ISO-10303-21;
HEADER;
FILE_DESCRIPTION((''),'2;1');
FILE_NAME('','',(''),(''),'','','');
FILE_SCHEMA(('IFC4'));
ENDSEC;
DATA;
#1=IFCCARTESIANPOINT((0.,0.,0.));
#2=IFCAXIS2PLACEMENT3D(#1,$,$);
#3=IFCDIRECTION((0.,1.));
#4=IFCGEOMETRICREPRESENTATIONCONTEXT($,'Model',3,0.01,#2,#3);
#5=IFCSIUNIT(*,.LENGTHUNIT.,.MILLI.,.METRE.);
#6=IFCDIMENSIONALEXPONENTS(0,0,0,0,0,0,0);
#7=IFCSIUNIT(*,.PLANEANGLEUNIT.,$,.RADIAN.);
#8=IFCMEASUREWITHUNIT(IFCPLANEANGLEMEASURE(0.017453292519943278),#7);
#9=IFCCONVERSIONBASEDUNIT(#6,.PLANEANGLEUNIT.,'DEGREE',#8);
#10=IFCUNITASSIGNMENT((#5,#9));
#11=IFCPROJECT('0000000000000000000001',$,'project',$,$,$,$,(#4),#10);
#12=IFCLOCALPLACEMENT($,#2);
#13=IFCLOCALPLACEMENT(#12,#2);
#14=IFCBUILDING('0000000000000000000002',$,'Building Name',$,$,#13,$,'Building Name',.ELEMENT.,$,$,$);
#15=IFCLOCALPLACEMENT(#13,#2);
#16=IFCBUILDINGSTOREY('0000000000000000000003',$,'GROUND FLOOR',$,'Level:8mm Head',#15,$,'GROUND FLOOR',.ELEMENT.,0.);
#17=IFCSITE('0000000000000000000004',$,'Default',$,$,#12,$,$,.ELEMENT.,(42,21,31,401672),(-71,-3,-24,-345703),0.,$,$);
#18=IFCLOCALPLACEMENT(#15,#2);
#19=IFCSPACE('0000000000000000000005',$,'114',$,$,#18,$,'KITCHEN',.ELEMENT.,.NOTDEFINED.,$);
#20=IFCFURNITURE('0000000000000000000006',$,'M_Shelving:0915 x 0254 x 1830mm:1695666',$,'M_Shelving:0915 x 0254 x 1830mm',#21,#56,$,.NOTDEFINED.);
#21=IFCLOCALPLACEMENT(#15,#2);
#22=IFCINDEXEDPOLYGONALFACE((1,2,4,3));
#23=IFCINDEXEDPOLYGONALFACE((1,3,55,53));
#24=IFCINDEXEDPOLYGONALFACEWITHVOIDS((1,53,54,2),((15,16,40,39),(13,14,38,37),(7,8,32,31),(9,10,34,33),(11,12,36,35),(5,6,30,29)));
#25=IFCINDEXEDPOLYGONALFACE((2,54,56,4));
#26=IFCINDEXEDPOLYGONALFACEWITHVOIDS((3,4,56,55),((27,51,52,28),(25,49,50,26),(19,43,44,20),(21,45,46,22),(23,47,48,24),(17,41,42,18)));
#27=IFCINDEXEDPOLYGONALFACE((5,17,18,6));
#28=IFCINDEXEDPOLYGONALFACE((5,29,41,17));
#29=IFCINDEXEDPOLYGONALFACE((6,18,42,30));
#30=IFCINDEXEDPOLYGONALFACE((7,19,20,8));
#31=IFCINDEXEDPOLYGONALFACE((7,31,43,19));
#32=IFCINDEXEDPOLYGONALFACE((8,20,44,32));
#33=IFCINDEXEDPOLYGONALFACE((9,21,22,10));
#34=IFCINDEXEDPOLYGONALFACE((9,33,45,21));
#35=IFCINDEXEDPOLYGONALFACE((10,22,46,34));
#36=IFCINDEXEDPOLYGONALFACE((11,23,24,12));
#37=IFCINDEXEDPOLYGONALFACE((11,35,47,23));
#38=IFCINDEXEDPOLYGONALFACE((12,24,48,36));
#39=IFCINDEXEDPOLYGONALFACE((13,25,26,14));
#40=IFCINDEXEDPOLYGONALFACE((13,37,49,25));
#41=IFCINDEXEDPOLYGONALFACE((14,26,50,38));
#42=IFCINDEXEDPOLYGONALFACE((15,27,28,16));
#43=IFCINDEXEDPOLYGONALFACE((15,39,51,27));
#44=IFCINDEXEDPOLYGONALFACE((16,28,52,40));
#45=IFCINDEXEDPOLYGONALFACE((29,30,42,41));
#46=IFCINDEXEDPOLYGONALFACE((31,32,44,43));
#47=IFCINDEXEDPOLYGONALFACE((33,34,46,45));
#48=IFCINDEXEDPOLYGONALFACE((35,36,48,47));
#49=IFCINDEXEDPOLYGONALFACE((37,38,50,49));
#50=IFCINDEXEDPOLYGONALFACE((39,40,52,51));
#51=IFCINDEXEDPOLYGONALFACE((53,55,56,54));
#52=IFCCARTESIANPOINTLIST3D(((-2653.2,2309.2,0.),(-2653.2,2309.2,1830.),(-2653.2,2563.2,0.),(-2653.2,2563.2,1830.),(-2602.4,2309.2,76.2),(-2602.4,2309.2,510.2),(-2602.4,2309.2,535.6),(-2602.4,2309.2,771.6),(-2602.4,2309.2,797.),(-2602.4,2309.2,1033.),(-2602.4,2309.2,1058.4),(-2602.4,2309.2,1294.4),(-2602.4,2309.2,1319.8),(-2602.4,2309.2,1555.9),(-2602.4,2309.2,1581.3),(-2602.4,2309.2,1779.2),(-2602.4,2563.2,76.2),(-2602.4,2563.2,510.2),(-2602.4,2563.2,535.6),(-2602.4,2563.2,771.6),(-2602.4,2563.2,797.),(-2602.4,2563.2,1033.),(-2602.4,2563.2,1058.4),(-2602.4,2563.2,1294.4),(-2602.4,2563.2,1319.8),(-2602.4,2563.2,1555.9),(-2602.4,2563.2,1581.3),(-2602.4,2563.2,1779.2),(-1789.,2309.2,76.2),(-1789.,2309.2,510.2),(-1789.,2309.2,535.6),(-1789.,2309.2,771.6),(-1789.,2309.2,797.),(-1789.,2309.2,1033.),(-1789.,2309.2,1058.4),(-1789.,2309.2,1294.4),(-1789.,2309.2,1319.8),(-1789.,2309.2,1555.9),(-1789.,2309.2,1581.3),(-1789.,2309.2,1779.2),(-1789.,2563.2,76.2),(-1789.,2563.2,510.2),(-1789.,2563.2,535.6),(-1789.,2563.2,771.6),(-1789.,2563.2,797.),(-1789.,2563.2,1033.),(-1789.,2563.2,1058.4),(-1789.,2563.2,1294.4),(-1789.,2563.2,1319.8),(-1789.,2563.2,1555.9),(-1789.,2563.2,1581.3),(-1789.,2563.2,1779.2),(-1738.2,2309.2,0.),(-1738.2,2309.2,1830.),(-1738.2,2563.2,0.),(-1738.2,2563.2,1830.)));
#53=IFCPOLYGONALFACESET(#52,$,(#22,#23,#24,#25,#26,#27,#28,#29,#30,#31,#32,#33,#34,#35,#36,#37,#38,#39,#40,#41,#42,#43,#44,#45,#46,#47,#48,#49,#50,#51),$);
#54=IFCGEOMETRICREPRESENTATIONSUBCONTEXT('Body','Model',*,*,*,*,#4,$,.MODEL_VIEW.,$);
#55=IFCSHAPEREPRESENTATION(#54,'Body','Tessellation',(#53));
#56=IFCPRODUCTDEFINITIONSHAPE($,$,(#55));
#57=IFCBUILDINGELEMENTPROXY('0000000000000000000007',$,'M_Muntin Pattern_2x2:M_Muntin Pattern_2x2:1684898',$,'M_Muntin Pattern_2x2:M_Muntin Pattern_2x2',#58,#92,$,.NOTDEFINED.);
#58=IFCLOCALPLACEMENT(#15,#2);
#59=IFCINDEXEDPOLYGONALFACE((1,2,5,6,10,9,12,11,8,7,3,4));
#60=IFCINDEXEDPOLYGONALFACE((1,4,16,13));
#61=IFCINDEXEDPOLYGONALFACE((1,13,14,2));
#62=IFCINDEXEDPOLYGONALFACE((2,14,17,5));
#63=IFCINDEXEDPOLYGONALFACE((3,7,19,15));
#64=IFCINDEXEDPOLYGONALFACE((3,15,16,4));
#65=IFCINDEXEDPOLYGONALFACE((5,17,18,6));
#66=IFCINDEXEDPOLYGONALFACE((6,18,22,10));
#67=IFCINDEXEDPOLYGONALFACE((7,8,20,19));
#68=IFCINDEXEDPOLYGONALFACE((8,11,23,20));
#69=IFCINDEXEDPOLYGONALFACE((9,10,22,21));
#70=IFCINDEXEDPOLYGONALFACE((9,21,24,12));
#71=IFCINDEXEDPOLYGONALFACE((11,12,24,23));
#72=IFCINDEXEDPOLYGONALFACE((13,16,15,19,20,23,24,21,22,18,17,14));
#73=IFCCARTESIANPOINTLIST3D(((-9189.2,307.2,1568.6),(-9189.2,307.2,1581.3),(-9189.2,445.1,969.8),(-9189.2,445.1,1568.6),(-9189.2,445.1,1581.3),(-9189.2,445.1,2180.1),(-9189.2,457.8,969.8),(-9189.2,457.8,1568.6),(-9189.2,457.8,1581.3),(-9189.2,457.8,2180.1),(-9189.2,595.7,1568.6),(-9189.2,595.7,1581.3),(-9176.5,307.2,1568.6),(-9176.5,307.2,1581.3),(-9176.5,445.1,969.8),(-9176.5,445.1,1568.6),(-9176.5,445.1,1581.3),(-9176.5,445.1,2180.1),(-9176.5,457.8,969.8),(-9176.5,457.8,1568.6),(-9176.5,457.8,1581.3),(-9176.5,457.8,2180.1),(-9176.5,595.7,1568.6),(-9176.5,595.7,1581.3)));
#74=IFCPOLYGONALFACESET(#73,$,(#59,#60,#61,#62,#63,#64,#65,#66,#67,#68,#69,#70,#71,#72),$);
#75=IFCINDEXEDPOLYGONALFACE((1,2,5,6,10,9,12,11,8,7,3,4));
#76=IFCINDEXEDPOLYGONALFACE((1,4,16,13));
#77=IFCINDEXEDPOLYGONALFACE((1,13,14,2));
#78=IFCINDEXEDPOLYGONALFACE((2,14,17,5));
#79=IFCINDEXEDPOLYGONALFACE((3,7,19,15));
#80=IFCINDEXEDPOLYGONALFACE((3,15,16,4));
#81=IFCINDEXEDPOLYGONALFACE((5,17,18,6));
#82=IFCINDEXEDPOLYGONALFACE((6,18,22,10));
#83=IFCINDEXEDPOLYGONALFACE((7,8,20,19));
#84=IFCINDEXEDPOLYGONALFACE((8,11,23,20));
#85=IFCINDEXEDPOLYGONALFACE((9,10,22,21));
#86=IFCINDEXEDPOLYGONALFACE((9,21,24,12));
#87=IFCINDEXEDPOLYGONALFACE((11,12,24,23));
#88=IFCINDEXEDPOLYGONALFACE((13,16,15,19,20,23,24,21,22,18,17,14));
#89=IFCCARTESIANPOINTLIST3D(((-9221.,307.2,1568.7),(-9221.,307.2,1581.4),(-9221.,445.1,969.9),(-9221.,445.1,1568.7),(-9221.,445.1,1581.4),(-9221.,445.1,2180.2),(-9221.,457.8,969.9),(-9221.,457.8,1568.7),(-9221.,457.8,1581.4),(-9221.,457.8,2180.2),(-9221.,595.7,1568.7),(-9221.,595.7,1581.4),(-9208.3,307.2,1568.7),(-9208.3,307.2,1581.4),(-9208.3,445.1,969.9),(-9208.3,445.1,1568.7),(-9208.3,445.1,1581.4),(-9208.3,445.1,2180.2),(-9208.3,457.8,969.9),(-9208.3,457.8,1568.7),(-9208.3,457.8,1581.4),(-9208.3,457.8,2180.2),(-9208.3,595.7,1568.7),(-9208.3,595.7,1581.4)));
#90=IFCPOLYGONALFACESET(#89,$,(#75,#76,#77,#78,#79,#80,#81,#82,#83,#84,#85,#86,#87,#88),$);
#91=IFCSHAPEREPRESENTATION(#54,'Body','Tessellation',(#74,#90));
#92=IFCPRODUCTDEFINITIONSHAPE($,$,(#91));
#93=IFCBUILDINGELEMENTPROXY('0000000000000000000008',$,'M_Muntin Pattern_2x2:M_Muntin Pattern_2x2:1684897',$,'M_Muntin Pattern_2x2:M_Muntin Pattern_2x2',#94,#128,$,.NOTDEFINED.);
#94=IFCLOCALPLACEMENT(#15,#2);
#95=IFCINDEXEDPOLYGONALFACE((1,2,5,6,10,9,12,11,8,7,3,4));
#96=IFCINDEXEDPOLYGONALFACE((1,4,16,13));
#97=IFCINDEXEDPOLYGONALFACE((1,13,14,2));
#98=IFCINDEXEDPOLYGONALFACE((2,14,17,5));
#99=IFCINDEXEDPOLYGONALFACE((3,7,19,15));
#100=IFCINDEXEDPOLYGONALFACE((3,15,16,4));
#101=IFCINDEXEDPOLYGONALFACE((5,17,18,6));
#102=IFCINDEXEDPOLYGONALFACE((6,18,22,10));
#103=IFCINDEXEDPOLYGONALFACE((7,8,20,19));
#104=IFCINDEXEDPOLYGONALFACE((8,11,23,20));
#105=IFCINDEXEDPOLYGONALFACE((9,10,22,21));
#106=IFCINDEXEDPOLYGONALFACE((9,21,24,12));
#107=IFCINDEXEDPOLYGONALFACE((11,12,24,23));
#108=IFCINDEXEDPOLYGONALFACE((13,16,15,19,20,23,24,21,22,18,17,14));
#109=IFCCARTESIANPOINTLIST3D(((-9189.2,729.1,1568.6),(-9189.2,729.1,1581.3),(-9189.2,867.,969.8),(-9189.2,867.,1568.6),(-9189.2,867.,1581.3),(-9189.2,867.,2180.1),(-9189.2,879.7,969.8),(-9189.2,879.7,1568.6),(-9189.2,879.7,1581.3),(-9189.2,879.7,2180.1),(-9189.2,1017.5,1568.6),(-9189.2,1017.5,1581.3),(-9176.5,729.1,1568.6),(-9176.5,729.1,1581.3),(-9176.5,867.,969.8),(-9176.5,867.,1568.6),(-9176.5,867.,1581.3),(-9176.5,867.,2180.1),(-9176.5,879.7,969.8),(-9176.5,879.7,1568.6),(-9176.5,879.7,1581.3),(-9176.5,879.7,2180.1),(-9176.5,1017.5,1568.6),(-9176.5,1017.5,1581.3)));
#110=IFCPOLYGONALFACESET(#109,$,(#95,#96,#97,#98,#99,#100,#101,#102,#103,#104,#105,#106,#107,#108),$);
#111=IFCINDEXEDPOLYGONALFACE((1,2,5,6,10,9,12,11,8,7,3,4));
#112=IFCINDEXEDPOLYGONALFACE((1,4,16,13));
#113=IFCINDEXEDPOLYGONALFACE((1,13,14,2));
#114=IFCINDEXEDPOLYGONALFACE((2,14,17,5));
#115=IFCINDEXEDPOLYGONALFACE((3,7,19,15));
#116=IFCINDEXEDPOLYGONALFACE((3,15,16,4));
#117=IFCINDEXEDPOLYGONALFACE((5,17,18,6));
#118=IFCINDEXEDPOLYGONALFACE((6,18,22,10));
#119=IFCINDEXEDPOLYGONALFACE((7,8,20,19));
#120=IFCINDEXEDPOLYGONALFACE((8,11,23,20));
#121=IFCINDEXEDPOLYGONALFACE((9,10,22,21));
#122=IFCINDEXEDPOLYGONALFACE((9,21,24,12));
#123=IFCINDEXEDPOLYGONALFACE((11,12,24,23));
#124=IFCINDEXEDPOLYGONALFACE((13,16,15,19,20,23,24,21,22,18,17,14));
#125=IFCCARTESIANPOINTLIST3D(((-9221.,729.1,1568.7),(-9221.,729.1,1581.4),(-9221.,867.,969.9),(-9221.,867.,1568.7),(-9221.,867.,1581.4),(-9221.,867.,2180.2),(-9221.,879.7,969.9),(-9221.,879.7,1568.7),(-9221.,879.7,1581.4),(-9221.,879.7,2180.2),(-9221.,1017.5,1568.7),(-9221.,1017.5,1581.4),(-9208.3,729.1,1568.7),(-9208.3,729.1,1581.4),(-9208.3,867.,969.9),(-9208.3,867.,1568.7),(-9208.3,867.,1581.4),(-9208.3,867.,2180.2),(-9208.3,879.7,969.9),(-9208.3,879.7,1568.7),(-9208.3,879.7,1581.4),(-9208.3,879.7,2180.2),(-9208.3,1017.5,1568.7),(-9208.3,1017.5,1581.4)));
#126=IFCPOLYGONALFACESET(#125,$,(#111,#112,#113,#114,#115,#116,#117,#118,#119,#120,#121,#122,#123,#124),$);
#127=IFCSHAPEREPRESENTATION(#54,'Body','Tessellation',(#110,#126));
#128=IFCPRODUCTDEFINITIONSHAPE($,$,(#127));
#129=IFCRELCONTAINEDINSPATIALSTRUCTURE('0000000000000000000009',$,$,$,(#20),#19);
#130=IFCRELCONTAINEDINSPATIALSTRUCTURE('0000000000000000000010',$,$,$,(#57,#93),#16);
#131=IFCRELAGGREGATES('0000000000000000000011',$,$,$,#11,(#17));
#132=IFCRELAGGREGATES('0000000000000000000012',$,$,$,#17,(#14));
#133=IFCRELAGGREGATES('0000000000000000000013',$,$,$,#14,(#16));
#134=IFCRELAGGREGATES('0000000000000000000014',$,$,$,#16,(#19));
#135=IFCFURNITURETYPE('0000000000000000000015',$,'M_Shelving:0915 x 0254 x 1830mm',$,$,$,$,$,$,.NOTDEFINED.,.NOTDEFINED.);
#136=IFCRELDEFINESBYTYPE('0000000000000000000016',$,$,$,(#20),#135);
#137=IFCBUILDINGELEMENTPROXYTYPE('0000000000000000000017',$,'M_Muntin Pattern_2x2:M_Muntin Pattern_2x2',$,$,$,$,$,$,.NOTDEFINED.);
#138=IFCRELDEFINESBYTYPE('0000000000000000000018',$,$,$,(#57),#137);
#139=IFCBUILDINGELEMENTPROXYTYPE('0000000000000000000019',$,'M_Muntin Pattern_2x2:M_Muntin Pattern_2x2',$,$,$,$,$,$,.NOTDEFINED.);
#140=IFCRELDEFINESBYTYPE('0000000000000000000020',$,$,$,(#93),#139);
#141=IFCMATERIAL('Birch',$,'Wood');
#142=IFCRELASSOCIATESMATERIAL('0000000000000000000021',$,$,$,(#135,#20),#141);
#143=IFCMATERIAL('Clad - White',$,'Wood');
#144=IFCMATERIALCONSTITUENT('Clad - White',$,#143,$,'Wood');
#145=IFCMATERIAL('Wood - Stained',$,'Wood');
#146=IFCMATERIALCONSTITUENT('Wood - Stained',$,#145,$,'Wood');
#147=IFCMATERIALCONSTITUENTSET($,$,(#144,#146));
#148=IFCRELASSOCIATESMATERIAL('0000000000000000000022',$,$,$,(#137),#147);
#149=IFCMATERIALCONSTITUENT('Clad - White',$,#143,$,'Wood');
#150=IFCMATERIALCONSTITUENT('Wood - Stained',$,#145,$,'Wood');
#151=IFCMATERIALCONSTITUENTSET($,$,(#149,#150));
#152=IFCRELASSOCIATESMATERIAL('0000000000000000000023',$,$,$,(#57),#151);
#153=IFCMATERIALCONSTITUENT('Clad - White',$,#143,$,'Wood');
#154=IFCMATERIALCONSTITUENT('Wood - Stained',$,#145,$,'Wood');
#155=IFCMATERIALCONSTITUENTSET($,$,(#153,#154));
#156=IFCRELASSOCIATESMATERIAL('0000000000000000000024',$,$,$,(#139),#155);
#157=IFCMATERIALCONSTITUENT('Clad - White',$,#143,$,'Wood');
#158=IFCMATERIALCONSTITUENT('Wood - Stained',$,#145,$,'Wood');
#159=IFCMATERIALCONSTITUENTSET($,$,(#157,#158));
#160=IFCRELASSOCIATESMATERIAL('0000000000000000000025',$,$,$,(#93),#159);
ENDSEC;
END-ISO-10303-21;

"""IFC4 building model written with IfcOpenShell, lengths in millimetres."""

from ifc_helpers import new_model, entity, si_unit, converted_unit, direction, frame, origin, place, context, subcontext, project, spatial, indexed_curve, outline, extrude, source, transform, mapped, material, constituent, constituent_set, type_object, type_shapes, element, save


model = new_model("IFC4")

# Units and contexts
model_context = context("Model", 3, precision=0.01, world=origin(), true_north=direction((0.0, 1.0)))
body_context = subcontext(model_context, "Body", "Model", "MODEL_VIEW")
ifc_project = project(units=[si_unit("LENGTHUNIT", "METRE", prefix="MILLI"), converted_unit("PLANEANGLEUNIT", "DEGREE", entity("IfcPlaneAngleMeasure", 0.017453292519943278), si_unit("PLANEANGLEUNIT", "RADIAN"), dimensions=[0, 0, 0, 0, 0, 0, 0])], contexts=[model_context])

# Site, building, storey
site_placement = place(None, origin())
site = spatial("IfcSite", under=ifc_project, at=site_placement, Name="Default", CompositionType="ELEMENT", RefLatitude=(42, 21, 31, 401672), RefLongitude=(-71, -3, -24, -345703), RefElevation=0.0)
building_placement = place(site_placement, origin())
building = spatial("IfcBuilding", under=site, at=building_placement, Name="Building Name", LongName="Building Name", CompositionType="ELEMENT")
storey_placement = place(building_placement, origin())
storey = spatial("IfcBuildingStorey", under=building, at=storey_placement, Name="GROUND FLOOR", ObjectType="Level:8mm Head", LongName="GROUND FLOOR", CompositionType="ELEMENT", Elevation=0.0)

# Shared definitions
ifc_material_1 = material(Name="Wood - Stained", Category="Wood")

# Shared definitions
space_1_placement = place(storey_placement, origin())
space_1 = spatial("IfcSpace", under=storey, at=space_1_placement, Name="114", LongName="KITCHEN", CompositionType="ELEMENT", PredefinedType="NOTDEFINED")

# Furniture
ifc_material_2 = material(Name="Birch", Category="Wood")
furniture_type_1 = type_object("IfcFurnitureType", Name="M_Shelving:0915 x 0254 x 1830mm", AssemblyPlace="NOTDEFINED", PredefinedType="NOTDEFINED", material=ifc_material_2)
shared_shape_1 = source(origin(), body_context, "Body", "SweptSolid", [
    extrude(outline(indexed_curve([(-457.5, -915.0), (457.5, -915.0), (457.5, 915.0), (-457.5, 915.0), (-457.5, -915.0)], self_intersect=False), holes=[indexed_curve([(-406.7, 864.2), (406.7, 864.2), (406.7, 666.3), (-406.7, 666.3), (-406.7, 864.2)], self_intersect=False), indexed_curve([(-406.7, -838.8), (-406.7, -404.8), (406.7, -404.8), (406.7, -838.8), (-406.7, -838.8)], self_intersect=False), indexed_curve([(406.7, 143.4), (-406.7, 143.4), (-406.7, 379.4), (406.7, 379.4), (406.7, 143.4)], self_intersect=False), indexed_curve([(-406.7, 640.9), (406.7, 640.9), (406.7, 404.8), (-406.7, 404.8), (-406.7, 640.9)], self_intersect=False), indexed_curve([(-406.7, 118.0), (406.7, 118.0), (406.7, -118.0), (-406.7, -118.0), (-406.7, 118.0)], self_intersect=False), indexed_curve([(-406.7, -143.4), (406.7, -143.4), (406.7, -379.4), (-406.7, -379.4), (-406.7, -143.4)], self_intersect=False)]), frame((0.0, -431.8, 915.0), z_axis=(0.0, 1.0, 0.0), x_axis=(-1.0, 0.0, 0.0)), (0.0, 0.0, 1.0), 254.0),
])
type_shapes(furniture_type_1, [shared_shape_1])
for number, where, name in (
    (1, (-2195.7, 2741.0, 0.0), "M_Shelving:0915 x 0254 x 1830mm:1695666"),
):
    element("IfcFurniture", number, at=place(space_1_placement, frame(where)), inside=space_1, type_object=furniture_type_1, material=ifc_material_2, Name=name, ObjectType="M_Shelving:0915 x 0254 x 1830mm", PredefinedType="NOTDEFINED", context=body_context, shape_type="MappedRepresentation", body=[
        mapped(shared_shape_1, transform((0.0, 0.0, 0.0), scale=1.0)),
    ])

# Building element proxies
ifc_material_3 = material(Name="Clad - White", Category="Wood")
ifc_constituent_1 = constituent(ifc_material_3, Name="Clad - White", Category="Wood")
ifc_constituent_2 = constituent(ifc_material_1, Name="Wood - Stained", Category="Wood")
ifc_constituent_set_1 = constituent_set(constituents=[ifc_constituent_1, ifc_constituent_2])
ifc_constituent_3 = constituent(ifc_material_3, Name="Clad - White", Category="Wood")
ifc_constituent_4 = constituent(ifc_material_1, Name="Wood - Stained", Category="Wood")
ifc_constituent_set_2 = constituent_set(constituents=[ifc_constituent_3, ifc_constituent_4])
building_element_proxy_type_1 = type_object("IfcBuildingElementProxyType", Name="M_Muntin Pattern_2x2:M_Muntin Pattern_2x2", PredefinedType="NOTDEFINED", material=ifc_constituent_set_2)
shared_shape_2 = source(origin(), body_context, "Body", "SweptSolid", [
    extrude(outline(indexed_curve([(6.4, -6.4), (605.1, -6.4), (605.1, 6.3), (6.4, 6.3), (6.4, 144.2), (-6.3, 144.2), (-6.3, 6.3), (-605.2, 6.3), (-605.2, -6.4), (-6.3, -6.4), (-6.3, -144.2), (6.4, -144.2), (6.4, -6.4)], self_intersect=False)), frame((0.0, -22.2, 605.1), z_axis=(0.0, 1.0, 0.0), x_axis=(0.0, 0.0, 1.0)), (0.0, 0.0, 1.0), 12.7),
    extrude(outline(indexed_curve([(6.4, -6.4), (605.2, -6.4), (605.2, 6.3), (6.4, 6.3), (6.4, 144.2), (-6.3, 144.2), (-6.3, 6.3), (-605.2, 6.3), (-605.2, -6.4), (-6.3, -6.4), (-6.3, -144.2), (6.4, -144.2), (6.4, -6.4)], self_intersect=False)), frame((0.0, 9.5, 605.2), z_axis=(0.0, 1.0, 0.0), x_axis=(0.0, 0.0, 1.0)), (0.0, 0.0, 1.0), 12.7),
])
type_shapes(building_element_proxy_type_1, [shared_shape_2])
proxy_1_placement = place(storey_placement, frame((-9198.7, 451.5, 969.9), z_axis=(0.0, 0.0, 1.0), x_axis=(0.0, 1.0, 0.0)))
element("IfcBuildingElementProxy", 2, at=proxy_1_placement, inside=storey, type_object=building_element_proxy_type_1, material=ifc_constituent_set_1, Name="M_Muntin Pattern_2x2:M_Muntin Pattern_2x2:1684898", ObjectType="M_Muntin Pattern_2x2:M_Muntin Pattern_2x2", PredefinedType="NOTDEFINED", context=body_context, shape_type="MappedRepresentation", body=[
    mapped(shared_shape_2, transform((0.0, 0.0, 0.0), scale=1.0)),
])
ifc_constituent_5 = constituent(ifc_material_3, Name="Clad - White", Category="Wood")
ifc_constituent_6 = constituent(ifc_material_1, Name="Wood - Stained", Category="Wood")
ifc_constituent_set_3 = constituent_set(constituents=[ifc_constituent_5, ifc_constituent_6])
ifc_constituent_7 = constituent(ifc_material_3, Name="Clad - White", Category="Wood")
ifc_constituent_8 = constituent(ifc_material_1, Name="Wood - Stained", Category="Wood")
ifc_constituent_set_4 = constituent_set(constituents=[ifc_constituent_7, ifc_constituent_8])
building_element_proxy_type_2 = type_object("IfcBuildingElementProxyType", Name="M_Muntin Pattern_2x2:M_Muntin Pattern_2x2", PredefinedType="NOTDEFINED", material=ifc_constituent_set_4)
shared_shape_3 = source(origin(), body_context, "Body", "SweptSolid", [
    extrude(outline(indexed_curve([(6.4, -6.4), (605.1, -6.4), (605.1, 6.3), (6.4, 6.3), (6.4, 144.2), (-6.3, 144.2), (-6.3, 6.3), (-605.2, 6.3), (-605.2, -6.4), (-6.3, -6.4), (-6.3, -144.2), (6.4, -144.2), (6.4, -6.4)], self_intersect=False)), frame((0.0, 9.5, 605.1), z_axis=(0.0, 1.0, 0.0), x_axis=(0.0, 0.0, 1.0)), (0.0, 0.0, 1.0), 12.7),
    extrude(outline(indexed_curve([(6.4, -6.4), (605.2, -6.4), (605.2, 6.3), (6.4, 6.3), (6.4, 144.2), (-6.3, 144.2), (-6.3, 6.3), (-605.2, 6.3), (-605.2, -6.4), (-6.3, -6.4), (-6.3, -144.2), (6.4, -144.2), (6.4, -6.4)], self_intersect=False)), frame((0.0, -22.2, 605.2), z_axis=(0.0, 1.0, 0.0), x_axis=(0.0, 0.0, 1.0)), (0.0, 0.0, 1.0), 12.7),
])
type_shapes(building_element_proxy_type_2, [shared_shape_3])
proxy_2_placement = place(storey_placement, frame((-9198.7, 873.3, 969.9), z_axis=(0.0, 0.0, 1.0), x_axis=(0.0, -1.0, 0.0)))
element("IfcBuildingElementProxy", 3, at=proxy_2_placement, inside=storey, type_object=building_element_proxy_type_2, material=ifc_constituent_set_3, Name="M_Muntin Pattern_2x2:M_Muntin Pattern_2x2:1684897", ObjectType="M_Muntin Pattern_2x2:M_Muntin Pattern_2x2", PredefinedType="NOTDEFINED", context=body_context, shape_type="MappedRepresentation", body=[
    mapped(shared_shape_3, transform((0.0, 0.0, 0.0), scale=1.0)),
])

save(model, "model.ifc")
